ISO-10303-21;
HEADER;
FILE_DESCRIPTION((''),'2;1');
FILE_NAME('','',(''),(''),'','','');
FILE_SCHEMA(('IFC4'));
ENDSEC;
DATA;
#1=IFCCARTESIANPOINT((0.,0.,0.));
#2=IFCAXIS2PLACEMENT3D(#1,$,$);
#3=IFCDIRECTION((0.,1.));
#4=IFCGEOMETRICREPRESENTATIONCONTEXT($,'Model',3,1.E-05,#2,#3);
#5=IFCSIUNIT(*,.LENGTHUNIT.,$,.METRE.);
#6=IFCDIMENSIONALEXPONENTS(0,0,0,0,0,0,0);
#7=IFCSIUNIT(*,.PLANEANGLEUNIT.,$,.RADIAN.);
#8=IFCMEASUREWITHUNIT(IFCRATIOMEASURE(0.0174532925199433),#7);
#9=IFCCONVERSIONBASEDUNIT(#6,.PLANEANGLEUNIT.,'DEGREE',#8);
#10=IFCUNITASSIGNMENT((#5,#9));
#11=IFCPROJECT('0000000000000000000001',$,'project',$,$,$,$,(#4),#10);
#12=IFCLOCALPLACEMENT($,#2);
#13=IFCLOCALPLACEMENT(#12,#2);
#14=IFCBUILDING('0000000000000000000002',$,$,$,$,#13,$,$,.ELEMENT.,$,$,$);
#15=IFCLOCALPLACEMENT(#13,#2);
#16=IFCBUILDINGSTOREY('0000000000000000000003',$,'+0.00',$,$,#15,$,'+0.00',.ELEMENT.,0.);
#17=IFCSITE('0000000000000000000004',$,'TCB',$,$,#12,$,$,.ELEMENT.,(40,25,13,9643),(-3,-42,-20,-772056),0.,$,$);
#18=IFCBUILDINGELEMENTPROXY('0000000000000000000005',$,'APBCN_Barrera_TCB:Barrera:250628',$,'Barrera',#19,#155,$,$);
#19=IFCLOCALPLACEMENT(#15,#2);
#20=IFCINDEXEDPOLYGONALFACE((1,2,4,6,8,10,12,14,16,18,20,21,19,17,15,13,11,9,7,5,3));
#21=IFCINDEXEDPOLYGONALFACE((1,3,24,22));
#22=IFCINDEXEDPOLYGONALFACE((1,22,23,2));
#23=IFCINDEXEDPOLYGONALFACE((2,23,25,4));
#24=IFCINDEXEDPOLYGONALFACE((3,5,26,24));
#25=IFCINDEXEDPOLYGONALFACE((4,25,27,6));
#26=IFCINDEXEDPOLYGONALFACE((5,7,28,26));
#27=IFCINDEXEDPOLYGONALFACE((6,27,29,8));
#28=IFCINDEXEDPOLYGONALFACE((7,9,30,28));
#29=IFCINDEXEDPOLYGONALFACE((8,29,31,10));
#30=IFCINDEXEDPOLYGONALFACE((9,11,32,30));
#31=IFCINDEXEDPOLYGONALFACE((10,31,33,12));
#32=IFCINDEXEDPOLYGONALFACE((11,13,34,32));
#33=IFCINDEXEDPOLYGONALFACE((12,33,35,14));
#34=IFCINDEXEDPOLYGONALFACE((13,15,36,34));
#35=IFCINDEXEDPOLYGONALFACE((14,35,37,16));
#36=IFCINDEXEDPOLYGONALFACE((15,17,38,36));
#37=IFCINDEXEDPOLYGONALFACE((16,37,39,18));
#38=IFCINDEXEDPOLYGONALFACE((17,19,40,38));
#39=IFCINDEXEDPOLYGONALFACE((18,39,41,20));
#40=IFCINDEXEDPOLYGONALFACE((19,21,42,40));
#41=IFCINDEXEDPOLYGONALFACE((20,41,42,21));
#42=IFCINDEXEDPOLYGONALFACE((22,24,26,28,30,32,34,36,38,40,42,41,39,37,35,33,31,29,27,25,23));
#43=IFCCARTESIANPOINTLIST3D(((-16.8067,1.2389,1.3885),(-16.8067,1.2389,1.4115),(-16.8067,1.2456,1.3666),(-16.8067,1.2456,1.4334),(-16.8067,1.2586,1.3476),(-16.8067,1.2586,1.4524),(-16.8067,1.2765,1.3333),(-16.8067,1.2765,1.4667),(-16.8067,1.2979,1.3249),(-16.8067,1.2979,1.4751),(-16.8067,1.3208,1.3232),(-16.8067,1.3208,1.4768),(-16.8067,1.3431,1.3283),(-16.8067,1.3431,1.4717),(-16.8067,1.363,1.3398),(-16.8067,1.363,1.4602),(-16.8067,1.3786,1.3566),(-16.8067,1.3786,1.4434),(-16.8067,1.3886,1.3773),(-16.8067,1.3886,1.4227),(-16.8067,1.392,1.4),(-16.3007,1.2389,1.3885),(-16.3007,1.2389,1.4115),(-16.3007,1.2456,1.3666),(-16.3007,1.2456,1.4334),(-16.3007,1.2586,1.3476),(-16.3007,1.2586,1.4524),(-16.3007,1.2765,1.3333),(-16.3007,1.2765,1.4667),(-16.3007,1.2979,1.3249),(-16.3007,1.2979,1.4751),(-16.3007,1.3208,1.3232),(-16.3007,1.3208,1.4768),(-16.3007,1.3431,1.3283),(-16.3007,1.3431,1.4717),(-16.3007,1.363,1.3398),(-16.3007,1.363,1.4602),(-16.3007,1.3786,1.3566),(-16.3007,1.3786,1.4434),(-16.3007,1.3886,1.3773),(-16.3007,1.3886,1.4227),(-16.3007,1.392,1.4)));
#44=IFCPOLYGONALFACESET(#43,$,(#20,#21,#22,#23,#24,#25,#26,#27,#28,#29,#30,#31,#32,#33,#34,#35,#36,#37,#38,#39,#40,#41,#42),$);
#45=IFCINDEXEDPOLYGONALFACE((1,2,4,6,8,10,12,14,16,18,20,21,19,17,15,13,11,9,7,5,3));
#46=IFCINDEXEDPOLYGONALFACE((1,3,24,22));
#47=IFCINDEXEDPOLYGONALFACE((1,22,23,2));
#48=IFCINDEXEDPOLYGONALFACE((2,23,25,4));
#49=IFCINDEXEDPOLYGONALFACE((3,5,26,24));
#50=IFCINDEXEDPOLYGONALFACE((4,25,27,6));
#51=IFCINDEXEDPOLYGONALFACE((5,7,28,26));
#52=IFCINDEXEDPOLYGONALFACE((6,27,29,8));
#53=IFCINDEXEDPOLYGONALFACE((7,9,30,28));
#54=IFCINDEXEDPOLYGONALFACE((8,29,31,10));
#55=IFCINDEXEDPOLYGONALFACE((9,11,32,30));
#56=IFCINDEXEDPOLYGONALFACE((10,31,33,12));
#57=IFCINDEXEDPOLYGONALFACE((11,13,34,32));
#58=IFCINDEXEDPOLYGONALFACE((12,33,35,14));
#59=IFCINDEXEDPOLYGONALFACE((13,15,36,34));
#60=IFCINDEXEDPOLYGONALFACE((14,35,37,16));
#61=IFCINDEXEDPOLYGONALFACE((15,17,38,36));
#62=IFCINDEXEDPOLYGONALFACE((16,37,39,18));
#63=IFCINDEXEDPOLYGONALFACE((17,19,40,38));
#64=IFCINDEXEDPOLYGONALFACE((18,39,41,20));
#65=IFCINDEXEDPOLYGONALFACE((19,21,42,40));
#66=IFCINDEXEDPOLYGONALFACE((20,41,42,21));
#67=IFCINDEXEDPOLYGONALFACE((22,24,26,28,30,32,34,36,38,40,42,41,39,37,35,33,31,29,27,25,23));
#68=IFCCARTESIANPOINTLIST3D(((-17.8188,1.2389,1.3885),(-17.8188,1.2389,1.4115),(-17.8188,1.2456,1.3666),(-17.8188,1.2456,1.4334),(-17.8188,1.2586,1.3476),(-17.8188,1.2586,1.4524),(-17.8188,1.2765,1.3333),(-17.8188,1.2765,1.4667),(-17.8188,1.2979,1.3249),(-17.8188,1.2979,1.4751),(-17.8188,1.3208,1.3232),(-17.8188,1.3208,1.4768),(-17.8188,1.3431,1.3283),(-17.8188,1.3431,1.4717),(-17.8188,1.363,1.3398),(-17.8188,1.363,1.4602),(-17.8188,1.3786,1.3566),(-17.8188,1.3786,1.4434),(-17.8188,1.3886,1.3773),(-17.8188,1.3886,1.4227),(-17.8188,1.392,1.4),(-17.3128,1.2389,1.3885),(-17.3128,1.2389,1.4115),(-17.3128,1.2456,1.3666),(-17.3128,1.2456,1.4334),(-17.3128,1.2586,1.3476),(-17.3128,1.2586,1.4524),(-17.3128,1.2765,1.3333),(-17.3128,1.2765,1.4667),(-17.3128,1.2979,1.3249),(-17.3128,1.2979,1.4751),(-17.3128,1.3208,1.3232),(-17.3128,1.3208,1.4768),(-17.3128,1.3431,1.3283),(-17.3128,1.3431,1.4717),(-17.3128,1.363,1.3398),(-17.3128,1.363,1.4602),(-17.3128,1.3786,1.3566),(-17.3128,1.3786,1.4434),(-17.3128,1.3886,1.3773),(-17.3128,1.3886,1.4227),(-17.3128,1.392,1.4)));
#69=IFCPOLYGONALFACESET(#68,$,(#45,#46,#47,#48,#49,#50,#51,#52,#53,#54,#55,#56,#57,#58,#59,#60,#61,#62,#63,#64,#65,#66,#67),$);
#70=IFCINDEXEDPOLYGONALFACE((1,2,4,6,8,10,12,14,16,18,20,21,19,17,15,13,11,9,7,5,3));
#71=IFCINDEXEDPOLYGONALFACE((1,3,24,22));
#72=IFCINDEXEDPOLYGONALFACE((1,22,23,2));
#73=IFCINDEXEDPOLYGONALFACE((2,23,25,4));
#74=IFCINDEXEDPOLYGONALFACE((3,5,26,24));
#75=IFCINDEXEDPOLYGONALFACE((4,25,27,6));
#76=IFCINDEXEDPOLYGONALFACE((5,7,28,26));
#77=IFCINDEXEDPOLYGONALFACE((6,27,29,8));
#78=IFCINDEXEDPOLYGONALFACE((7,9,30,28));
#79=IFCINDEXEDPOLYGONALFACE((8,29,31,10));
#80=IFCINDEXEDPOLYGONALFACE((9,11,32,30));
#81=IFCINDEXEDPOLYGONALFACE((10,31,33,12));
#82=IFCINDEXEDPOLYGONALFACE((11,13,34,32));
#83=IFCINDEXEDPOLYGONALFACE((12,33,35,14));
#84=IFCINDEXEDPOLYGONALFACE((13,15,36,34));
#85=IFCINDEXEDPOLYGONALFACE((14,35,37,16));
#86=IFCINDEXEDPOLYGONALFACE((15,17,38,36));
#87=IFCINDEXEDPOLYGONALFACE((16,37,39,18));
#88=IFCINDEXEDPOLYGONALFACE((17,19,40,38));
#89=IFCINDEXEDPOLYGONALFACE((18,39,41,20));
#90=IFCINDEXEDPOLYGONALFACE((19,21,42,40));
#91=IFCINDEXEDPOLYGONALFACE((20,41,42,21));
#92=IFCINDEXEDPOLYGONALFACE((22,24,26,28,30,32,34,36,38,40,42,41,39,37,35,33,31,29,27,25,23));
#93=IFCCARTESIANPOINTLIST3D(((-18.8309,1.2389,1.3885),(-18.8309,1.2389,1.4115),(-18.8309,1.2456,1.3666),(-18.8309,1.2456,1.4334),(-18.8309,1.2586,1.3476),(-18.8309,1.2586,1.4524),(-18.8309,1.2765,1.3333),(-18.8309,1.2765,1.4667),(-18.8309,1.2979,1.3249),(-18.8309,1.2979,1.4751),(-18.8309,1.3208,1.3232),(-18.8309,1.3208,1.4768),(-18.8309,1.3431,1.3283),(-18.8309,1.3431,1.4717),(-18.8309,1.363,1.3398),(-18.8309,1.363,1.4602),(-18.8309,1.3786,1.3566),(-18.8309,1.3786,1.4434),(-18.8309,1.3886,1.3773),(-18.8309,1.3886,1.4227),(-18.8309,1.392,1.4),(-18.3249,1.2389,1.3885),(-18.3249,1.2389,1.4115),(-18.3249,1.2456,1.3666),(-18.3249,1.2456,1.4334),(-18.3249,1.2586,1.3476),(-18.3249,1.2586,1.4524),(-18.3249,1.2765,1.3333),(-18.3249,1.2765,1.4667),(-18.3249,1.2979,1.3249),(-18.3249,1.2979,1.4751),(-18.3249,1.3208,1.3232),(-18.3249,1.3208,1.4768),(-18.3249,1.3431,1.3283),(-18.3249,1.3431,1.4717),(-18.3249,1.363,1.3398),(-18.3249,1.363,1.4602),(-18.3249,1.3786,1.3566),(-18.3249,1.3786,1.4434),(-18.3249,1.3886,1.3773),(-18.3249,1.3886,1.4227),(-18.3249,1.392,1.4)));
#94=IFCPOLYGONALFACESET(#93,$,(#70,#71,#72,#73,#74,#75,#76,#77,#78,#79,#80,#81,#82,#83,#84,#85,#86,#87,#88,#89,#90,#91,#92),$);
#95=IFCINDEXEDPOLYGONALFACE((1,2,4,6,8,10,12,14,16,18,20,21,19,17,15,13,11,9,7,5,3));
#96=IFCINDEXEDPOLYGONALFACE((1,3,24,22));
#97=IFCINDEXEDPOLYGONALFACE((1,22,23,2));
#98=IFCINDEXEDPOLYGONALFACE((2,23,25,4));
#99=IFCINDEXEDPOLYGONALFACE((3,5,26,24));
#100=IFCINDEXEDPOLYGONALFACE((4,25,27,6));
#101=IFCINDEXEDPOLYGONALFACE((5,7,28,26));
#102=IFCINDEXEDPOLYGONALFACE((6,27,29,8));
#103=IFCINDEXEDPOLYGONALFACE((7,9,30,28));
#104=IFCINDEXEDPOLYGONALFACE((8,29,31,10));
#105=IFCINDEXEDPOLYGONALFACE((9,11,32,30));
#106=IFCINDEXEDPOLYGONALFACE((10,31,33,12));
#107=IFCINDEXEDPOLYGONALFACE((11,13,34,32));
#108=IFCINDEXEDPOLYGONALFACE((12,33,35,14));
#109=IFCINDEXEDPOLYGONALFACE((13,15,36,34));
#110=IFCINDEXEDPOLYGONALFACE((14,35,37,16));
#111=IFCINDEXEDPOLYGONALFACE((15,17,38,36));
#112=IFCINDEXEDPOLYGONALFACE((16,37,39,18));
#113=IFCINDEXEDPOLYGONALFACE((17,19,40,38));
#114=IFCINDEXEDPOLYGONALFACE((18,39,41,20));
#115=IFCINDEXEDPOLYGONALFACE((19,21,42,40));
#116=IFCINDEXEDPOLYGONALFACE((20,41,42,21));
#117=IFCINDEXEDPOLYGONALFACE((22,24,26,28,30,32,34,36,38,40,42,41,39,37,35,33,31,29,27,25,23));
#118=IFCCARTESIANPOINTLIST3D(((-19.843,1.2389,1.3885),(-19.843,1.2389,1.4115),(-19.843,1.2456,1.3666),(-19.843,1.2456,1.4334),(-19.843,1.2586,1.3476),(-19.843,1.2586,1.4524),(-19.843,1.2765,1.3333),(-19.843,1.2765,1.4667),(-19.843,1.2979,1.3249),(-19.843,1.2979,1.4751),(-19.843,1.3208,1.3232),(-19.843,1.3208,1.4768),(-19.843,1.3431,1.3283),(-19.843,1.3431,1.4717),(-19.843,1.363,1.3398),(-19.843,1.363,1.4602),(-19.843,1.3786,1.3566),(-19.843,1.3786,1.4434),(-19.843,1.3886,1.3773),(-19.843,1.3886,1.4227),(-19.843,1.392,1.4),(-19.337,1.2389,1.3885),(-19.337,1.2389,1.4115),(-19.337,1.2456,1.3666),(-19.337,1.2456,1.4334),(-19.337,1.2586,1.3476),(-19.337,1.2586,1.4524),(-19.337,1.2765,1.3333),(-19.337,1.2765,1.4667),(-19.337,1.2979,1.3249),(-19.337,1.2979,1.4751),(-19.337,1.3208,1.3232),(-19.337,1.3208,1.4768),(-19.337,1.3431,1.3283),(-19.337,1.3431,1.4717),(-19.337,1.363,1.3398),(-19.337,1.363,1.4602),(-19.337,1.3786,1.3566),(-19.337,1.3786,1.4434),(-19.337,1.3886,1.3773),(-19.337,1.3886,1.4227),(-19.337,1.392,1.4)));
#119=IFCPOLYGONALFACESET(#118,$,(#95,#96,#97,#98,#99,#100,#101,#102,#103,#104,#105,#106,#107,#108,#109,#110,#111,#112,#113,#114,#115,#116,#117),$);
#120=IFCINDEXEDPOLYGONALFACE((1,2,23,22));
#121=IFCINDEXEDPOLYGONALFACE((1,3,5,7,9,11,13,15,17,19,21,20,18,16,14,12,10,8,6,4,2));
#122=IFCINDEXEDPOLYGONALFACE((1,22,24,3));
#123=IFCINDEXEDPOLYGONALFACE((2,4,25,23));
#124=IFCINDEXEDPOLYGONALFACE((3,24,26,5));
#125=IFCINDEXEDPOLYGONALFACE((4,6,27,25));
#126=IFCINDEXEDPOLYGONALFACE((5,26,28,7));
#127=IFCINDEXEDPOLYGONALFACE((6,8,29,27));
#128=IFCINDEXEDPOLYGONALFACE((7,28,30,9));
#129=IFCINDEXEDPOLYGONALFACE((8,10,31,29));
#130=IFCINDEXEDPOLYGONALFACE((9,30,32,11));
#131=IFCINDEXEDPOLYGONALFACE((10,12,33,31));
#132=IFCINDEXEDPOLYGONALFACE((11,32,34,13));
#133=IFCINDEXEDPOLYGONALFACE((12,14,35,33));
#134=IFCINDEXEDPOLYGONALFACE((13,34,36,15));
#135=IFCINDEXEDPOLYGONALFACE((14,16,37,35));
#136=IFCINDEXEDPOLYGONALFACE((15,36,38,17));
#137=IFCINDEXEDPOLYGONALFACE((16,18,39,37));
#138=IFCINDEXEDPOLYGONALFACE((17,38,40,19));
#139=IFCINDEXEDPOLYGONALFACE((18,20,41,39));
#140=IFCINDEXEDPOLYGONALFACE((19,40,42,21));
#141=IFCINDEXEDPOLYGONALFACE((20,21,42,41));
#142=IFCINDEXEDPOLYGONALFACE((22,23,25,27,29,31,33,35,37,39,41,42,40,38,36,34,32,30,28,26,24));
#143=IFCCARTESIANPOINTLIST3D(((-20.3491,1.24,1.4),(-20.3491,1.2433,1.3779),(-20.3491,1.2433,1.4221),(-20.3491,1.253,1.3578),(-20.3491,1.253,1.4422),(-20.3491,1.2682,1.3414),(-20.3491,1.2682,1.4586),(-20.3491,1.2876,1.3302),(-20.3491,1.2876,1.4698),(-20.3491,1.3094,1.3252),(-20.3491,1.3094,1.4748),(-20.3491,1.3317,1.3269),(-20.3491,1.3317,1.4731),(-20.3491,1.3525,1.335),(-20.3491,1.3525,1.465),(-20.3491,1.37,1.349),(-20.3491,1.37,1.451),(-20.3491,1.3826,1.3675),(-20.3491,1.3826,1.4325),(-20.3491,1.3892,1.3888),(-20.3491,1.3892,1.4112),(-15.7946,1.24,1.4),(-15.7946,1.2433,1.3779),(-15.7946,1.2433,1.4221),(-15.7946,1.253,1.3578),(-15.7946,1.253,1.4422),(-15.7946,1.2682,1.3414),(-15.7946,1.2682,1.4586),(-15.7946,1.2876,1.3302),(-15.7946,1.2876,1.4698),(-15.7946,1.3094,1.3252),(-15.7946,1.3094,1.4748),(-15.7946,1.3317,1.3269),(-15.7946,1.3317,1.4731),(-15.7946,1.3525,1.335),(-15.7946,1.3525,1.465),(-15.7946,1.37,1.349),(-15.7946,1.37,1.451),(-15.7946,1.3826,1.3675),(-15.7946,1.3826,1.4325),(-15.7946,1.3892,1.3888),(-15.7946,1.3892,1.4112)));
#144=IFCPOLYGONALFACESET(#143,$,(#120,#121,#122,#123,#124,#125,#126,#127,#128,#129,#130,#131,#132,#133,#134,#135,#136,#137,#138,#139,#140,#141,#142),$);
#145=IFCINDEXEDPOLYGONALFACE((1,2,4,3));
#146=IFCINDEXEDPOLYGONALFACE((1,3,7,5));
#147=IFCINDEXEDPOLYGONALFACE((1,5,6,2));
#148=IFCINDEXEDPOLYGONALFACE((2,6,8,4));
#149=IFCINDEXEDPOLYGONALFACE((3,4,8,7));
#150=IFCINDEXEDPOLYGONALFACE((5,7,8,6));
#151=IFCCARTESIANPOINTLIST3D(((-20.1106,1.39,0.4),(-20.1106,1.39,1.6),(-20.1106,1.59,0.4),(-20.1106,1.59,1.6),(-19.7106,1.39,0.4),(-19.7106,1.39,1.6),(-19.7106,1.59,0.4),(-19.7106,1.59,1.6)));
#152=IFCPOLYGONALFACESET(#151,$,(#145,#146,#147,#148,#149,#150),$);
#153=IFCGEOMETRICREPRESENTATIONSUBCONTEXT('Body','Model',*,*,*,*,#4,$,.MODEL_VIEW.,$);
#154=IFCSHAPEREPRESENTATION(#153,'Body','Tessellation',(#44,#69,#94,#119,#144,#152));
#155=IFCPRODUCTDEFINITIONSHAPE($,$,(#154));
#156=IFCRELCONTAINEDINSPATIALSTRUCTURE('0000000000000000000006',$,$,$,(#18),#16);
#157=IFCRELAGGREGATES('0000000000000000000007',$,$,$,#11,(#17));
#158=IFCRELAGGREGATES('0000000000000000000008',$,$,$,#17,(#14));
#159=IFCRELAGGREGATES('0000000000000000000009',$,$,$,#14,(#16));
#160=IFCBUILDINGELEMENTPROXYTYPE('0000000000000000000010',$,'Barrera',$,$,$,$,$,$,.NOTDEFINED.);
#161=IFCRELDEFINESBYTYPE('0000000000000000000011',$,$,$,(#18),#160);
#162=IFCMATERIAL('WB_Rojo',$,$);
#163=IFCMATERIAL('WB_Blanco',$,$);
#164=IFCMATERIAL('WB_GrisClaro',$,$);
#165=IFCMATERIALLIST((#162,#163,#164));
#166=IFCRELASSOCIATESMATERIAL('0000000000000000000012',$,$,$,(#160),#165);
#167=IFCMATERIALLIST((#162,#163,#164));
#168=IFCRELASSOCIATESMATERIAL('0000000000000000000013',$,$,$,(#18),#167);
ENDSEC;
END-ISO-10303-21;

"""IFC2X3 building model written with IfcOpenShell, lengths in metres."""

from ifc_helpers import new_model, entity, si_unit, converted_unit, direction, frame, frame_2d, origin, place, context, subcontext, project, spatial, rectangle, circle, extrude, source, transform, mapped, material, material_list, type_object, type_shapes, element, save


model = new_model("IFC2X3")

# Units and contexts
model_context = context("Model", 3, precision=1e-05, world=origin(), true_north=direction((0.0, 1.0)))
body_context = subcontext(model_context, "Body", "Model", "MODEL_VIEW")
ifc_project = project(units=[si_unit("LENGTHUNIT", "METRE"), converted_unit("PLANEANGLEUNIT", "DEGREE", entity("IfcRatioMeasure", 0.0174532925199433), si_unit("PLANEANGLEUNIT", "RADIAN"), dimensions=[0, 0, 0, 0, 0, 0, 0])], contexts=[model_context])

# Site, building, storey
site_placement = place(None, origin())
site = spatial("IfcSite", under=ifc_project, at=site_placement, Name="TCB", CompositionType="ELEMENT", RefLatitude=(40, 25, 13, 9643), RefLongitude=(-3, -42, -20, -772056), RefElevation=0.0)
building_placement = place(site_placement, origin())
building = spatial("IfcBuilding", under=site, at=building_placement, CompositionType="ELEMENT")
storey_placement = place(building_placement, origin())
storey = spatial("IfcBuildingStorey", under=building, at=storey_placement, Name="+0.00", LongName="+0.00", CompositionType="ELEMENT", Elevation=0.0)

# Shared definitions
ifc_material_1 = material(Name="WB_Blanco")

# Building element proxy
ifc_material_2 = material(Name="WB_Rojo")
ifc_material_3 = material(Name="WB_GrisClaro")
ifc_material_list_1 = material_list([ifc_material_2, ifc_material_1, ifc_material_3])
building_element_proxy_type = type_object("IfcBuildingElementProxyType", Name="Barrera", PredefinedType="NOTDEFINED", material=ifc_material_list_1)
shared_shape_1 = source(origin(), body_context, "Body", "SweptSolid", [
    extrude(circle(Radius=0.077, at=frame_2d((0.0, 0.0), x_axis=(1.0, 0.0))), frame((2.8039, -0.175, 1.0), z_axis=(1.0, 0.0, 0.0), x_axis=(0.0, 1.0, 0.0)), (0.0, 0.0, 1.0), 0.506),
    extrude(circle(Radius=0.077, at=frame_2d((0.0, 0.0), x_axis=(1.0, 0.0))), frame((1.7918, -0.175, 1.0), z_axis=(1.0, 0.0, 0.0), x_axis=(0.0, 1.0, 0.0)), (0.0, 0.0, 1.0), 0.506),
    extrude(circle(Radius=0.077, at=frame_2d((0.0, 0.0), x_axis=(1.0, 0.0))), frame((0.7797, -0.175, 1.0), z_axis=(1.0, 0.0, 0.0), x_axis=(0.0, 1.0, 0.0)), (0.0, 0.0, 1.0), 0.506),
    extrude(circle(Radius=0.077, at=frame_2d((0.0, 0.0), x_axis=(1.0, 0.0))), frame((-0.2324, -0.175, 1.0), z_axis=(1.0, 0.0, 0.0), x_axis=(0.0, 1.0, 0.0)), (0.0, 0.0, 1.0), 0.506),
    extrude(circle(Radius=0.075, at=frame_2d((0.0, 0.0), x_axis=(1.0, 0.0))), frame((-0.7385, -0.175, 1.0), z_axis=(1.0, 0.0, 0.0), x_axis=(0.0, -1.0, 0.0)), (0.0, 0.0, 1.0), 4.5544),
    extrude(rectangle(XDim=0.2, YDim=0.4, at=frame_2d((0.0, 0.0), x_axis=(1.0, 0.0))), frame((-0.3, 0.0, 0.0), z_axis=(0.0, 0.0, 1.0), x_axis=(0.0, -1.0, 0.0)), (0.0, 0.0, 1.0), 1.2),
])
type_shapes(building_element_proxy_type, [shared_shape_1])
ifc_material_list_2 = material_list([ifc_material_2, ifc_material_1, ifc_material_3])
proxy_1_placement = place(storey_placement, frame((-19.6106, 1.49, 0.4)))
element("IfcBuildingElementProxy", 1, at=proxy_1_placement, inside=storey, type_object=building_element_proxy_type, material=ifc_material_list_2, Name="APBCN_Barrera_TCB:Barrera:250628", ObjectType="Barrera", context=body_context, shape_type="MappedRepresentation", body=[
    mapped(shared_shape_1, transform((0.0, 0.0, 0.0), scale=1.0)),
])

save(model, "model.ifc")
